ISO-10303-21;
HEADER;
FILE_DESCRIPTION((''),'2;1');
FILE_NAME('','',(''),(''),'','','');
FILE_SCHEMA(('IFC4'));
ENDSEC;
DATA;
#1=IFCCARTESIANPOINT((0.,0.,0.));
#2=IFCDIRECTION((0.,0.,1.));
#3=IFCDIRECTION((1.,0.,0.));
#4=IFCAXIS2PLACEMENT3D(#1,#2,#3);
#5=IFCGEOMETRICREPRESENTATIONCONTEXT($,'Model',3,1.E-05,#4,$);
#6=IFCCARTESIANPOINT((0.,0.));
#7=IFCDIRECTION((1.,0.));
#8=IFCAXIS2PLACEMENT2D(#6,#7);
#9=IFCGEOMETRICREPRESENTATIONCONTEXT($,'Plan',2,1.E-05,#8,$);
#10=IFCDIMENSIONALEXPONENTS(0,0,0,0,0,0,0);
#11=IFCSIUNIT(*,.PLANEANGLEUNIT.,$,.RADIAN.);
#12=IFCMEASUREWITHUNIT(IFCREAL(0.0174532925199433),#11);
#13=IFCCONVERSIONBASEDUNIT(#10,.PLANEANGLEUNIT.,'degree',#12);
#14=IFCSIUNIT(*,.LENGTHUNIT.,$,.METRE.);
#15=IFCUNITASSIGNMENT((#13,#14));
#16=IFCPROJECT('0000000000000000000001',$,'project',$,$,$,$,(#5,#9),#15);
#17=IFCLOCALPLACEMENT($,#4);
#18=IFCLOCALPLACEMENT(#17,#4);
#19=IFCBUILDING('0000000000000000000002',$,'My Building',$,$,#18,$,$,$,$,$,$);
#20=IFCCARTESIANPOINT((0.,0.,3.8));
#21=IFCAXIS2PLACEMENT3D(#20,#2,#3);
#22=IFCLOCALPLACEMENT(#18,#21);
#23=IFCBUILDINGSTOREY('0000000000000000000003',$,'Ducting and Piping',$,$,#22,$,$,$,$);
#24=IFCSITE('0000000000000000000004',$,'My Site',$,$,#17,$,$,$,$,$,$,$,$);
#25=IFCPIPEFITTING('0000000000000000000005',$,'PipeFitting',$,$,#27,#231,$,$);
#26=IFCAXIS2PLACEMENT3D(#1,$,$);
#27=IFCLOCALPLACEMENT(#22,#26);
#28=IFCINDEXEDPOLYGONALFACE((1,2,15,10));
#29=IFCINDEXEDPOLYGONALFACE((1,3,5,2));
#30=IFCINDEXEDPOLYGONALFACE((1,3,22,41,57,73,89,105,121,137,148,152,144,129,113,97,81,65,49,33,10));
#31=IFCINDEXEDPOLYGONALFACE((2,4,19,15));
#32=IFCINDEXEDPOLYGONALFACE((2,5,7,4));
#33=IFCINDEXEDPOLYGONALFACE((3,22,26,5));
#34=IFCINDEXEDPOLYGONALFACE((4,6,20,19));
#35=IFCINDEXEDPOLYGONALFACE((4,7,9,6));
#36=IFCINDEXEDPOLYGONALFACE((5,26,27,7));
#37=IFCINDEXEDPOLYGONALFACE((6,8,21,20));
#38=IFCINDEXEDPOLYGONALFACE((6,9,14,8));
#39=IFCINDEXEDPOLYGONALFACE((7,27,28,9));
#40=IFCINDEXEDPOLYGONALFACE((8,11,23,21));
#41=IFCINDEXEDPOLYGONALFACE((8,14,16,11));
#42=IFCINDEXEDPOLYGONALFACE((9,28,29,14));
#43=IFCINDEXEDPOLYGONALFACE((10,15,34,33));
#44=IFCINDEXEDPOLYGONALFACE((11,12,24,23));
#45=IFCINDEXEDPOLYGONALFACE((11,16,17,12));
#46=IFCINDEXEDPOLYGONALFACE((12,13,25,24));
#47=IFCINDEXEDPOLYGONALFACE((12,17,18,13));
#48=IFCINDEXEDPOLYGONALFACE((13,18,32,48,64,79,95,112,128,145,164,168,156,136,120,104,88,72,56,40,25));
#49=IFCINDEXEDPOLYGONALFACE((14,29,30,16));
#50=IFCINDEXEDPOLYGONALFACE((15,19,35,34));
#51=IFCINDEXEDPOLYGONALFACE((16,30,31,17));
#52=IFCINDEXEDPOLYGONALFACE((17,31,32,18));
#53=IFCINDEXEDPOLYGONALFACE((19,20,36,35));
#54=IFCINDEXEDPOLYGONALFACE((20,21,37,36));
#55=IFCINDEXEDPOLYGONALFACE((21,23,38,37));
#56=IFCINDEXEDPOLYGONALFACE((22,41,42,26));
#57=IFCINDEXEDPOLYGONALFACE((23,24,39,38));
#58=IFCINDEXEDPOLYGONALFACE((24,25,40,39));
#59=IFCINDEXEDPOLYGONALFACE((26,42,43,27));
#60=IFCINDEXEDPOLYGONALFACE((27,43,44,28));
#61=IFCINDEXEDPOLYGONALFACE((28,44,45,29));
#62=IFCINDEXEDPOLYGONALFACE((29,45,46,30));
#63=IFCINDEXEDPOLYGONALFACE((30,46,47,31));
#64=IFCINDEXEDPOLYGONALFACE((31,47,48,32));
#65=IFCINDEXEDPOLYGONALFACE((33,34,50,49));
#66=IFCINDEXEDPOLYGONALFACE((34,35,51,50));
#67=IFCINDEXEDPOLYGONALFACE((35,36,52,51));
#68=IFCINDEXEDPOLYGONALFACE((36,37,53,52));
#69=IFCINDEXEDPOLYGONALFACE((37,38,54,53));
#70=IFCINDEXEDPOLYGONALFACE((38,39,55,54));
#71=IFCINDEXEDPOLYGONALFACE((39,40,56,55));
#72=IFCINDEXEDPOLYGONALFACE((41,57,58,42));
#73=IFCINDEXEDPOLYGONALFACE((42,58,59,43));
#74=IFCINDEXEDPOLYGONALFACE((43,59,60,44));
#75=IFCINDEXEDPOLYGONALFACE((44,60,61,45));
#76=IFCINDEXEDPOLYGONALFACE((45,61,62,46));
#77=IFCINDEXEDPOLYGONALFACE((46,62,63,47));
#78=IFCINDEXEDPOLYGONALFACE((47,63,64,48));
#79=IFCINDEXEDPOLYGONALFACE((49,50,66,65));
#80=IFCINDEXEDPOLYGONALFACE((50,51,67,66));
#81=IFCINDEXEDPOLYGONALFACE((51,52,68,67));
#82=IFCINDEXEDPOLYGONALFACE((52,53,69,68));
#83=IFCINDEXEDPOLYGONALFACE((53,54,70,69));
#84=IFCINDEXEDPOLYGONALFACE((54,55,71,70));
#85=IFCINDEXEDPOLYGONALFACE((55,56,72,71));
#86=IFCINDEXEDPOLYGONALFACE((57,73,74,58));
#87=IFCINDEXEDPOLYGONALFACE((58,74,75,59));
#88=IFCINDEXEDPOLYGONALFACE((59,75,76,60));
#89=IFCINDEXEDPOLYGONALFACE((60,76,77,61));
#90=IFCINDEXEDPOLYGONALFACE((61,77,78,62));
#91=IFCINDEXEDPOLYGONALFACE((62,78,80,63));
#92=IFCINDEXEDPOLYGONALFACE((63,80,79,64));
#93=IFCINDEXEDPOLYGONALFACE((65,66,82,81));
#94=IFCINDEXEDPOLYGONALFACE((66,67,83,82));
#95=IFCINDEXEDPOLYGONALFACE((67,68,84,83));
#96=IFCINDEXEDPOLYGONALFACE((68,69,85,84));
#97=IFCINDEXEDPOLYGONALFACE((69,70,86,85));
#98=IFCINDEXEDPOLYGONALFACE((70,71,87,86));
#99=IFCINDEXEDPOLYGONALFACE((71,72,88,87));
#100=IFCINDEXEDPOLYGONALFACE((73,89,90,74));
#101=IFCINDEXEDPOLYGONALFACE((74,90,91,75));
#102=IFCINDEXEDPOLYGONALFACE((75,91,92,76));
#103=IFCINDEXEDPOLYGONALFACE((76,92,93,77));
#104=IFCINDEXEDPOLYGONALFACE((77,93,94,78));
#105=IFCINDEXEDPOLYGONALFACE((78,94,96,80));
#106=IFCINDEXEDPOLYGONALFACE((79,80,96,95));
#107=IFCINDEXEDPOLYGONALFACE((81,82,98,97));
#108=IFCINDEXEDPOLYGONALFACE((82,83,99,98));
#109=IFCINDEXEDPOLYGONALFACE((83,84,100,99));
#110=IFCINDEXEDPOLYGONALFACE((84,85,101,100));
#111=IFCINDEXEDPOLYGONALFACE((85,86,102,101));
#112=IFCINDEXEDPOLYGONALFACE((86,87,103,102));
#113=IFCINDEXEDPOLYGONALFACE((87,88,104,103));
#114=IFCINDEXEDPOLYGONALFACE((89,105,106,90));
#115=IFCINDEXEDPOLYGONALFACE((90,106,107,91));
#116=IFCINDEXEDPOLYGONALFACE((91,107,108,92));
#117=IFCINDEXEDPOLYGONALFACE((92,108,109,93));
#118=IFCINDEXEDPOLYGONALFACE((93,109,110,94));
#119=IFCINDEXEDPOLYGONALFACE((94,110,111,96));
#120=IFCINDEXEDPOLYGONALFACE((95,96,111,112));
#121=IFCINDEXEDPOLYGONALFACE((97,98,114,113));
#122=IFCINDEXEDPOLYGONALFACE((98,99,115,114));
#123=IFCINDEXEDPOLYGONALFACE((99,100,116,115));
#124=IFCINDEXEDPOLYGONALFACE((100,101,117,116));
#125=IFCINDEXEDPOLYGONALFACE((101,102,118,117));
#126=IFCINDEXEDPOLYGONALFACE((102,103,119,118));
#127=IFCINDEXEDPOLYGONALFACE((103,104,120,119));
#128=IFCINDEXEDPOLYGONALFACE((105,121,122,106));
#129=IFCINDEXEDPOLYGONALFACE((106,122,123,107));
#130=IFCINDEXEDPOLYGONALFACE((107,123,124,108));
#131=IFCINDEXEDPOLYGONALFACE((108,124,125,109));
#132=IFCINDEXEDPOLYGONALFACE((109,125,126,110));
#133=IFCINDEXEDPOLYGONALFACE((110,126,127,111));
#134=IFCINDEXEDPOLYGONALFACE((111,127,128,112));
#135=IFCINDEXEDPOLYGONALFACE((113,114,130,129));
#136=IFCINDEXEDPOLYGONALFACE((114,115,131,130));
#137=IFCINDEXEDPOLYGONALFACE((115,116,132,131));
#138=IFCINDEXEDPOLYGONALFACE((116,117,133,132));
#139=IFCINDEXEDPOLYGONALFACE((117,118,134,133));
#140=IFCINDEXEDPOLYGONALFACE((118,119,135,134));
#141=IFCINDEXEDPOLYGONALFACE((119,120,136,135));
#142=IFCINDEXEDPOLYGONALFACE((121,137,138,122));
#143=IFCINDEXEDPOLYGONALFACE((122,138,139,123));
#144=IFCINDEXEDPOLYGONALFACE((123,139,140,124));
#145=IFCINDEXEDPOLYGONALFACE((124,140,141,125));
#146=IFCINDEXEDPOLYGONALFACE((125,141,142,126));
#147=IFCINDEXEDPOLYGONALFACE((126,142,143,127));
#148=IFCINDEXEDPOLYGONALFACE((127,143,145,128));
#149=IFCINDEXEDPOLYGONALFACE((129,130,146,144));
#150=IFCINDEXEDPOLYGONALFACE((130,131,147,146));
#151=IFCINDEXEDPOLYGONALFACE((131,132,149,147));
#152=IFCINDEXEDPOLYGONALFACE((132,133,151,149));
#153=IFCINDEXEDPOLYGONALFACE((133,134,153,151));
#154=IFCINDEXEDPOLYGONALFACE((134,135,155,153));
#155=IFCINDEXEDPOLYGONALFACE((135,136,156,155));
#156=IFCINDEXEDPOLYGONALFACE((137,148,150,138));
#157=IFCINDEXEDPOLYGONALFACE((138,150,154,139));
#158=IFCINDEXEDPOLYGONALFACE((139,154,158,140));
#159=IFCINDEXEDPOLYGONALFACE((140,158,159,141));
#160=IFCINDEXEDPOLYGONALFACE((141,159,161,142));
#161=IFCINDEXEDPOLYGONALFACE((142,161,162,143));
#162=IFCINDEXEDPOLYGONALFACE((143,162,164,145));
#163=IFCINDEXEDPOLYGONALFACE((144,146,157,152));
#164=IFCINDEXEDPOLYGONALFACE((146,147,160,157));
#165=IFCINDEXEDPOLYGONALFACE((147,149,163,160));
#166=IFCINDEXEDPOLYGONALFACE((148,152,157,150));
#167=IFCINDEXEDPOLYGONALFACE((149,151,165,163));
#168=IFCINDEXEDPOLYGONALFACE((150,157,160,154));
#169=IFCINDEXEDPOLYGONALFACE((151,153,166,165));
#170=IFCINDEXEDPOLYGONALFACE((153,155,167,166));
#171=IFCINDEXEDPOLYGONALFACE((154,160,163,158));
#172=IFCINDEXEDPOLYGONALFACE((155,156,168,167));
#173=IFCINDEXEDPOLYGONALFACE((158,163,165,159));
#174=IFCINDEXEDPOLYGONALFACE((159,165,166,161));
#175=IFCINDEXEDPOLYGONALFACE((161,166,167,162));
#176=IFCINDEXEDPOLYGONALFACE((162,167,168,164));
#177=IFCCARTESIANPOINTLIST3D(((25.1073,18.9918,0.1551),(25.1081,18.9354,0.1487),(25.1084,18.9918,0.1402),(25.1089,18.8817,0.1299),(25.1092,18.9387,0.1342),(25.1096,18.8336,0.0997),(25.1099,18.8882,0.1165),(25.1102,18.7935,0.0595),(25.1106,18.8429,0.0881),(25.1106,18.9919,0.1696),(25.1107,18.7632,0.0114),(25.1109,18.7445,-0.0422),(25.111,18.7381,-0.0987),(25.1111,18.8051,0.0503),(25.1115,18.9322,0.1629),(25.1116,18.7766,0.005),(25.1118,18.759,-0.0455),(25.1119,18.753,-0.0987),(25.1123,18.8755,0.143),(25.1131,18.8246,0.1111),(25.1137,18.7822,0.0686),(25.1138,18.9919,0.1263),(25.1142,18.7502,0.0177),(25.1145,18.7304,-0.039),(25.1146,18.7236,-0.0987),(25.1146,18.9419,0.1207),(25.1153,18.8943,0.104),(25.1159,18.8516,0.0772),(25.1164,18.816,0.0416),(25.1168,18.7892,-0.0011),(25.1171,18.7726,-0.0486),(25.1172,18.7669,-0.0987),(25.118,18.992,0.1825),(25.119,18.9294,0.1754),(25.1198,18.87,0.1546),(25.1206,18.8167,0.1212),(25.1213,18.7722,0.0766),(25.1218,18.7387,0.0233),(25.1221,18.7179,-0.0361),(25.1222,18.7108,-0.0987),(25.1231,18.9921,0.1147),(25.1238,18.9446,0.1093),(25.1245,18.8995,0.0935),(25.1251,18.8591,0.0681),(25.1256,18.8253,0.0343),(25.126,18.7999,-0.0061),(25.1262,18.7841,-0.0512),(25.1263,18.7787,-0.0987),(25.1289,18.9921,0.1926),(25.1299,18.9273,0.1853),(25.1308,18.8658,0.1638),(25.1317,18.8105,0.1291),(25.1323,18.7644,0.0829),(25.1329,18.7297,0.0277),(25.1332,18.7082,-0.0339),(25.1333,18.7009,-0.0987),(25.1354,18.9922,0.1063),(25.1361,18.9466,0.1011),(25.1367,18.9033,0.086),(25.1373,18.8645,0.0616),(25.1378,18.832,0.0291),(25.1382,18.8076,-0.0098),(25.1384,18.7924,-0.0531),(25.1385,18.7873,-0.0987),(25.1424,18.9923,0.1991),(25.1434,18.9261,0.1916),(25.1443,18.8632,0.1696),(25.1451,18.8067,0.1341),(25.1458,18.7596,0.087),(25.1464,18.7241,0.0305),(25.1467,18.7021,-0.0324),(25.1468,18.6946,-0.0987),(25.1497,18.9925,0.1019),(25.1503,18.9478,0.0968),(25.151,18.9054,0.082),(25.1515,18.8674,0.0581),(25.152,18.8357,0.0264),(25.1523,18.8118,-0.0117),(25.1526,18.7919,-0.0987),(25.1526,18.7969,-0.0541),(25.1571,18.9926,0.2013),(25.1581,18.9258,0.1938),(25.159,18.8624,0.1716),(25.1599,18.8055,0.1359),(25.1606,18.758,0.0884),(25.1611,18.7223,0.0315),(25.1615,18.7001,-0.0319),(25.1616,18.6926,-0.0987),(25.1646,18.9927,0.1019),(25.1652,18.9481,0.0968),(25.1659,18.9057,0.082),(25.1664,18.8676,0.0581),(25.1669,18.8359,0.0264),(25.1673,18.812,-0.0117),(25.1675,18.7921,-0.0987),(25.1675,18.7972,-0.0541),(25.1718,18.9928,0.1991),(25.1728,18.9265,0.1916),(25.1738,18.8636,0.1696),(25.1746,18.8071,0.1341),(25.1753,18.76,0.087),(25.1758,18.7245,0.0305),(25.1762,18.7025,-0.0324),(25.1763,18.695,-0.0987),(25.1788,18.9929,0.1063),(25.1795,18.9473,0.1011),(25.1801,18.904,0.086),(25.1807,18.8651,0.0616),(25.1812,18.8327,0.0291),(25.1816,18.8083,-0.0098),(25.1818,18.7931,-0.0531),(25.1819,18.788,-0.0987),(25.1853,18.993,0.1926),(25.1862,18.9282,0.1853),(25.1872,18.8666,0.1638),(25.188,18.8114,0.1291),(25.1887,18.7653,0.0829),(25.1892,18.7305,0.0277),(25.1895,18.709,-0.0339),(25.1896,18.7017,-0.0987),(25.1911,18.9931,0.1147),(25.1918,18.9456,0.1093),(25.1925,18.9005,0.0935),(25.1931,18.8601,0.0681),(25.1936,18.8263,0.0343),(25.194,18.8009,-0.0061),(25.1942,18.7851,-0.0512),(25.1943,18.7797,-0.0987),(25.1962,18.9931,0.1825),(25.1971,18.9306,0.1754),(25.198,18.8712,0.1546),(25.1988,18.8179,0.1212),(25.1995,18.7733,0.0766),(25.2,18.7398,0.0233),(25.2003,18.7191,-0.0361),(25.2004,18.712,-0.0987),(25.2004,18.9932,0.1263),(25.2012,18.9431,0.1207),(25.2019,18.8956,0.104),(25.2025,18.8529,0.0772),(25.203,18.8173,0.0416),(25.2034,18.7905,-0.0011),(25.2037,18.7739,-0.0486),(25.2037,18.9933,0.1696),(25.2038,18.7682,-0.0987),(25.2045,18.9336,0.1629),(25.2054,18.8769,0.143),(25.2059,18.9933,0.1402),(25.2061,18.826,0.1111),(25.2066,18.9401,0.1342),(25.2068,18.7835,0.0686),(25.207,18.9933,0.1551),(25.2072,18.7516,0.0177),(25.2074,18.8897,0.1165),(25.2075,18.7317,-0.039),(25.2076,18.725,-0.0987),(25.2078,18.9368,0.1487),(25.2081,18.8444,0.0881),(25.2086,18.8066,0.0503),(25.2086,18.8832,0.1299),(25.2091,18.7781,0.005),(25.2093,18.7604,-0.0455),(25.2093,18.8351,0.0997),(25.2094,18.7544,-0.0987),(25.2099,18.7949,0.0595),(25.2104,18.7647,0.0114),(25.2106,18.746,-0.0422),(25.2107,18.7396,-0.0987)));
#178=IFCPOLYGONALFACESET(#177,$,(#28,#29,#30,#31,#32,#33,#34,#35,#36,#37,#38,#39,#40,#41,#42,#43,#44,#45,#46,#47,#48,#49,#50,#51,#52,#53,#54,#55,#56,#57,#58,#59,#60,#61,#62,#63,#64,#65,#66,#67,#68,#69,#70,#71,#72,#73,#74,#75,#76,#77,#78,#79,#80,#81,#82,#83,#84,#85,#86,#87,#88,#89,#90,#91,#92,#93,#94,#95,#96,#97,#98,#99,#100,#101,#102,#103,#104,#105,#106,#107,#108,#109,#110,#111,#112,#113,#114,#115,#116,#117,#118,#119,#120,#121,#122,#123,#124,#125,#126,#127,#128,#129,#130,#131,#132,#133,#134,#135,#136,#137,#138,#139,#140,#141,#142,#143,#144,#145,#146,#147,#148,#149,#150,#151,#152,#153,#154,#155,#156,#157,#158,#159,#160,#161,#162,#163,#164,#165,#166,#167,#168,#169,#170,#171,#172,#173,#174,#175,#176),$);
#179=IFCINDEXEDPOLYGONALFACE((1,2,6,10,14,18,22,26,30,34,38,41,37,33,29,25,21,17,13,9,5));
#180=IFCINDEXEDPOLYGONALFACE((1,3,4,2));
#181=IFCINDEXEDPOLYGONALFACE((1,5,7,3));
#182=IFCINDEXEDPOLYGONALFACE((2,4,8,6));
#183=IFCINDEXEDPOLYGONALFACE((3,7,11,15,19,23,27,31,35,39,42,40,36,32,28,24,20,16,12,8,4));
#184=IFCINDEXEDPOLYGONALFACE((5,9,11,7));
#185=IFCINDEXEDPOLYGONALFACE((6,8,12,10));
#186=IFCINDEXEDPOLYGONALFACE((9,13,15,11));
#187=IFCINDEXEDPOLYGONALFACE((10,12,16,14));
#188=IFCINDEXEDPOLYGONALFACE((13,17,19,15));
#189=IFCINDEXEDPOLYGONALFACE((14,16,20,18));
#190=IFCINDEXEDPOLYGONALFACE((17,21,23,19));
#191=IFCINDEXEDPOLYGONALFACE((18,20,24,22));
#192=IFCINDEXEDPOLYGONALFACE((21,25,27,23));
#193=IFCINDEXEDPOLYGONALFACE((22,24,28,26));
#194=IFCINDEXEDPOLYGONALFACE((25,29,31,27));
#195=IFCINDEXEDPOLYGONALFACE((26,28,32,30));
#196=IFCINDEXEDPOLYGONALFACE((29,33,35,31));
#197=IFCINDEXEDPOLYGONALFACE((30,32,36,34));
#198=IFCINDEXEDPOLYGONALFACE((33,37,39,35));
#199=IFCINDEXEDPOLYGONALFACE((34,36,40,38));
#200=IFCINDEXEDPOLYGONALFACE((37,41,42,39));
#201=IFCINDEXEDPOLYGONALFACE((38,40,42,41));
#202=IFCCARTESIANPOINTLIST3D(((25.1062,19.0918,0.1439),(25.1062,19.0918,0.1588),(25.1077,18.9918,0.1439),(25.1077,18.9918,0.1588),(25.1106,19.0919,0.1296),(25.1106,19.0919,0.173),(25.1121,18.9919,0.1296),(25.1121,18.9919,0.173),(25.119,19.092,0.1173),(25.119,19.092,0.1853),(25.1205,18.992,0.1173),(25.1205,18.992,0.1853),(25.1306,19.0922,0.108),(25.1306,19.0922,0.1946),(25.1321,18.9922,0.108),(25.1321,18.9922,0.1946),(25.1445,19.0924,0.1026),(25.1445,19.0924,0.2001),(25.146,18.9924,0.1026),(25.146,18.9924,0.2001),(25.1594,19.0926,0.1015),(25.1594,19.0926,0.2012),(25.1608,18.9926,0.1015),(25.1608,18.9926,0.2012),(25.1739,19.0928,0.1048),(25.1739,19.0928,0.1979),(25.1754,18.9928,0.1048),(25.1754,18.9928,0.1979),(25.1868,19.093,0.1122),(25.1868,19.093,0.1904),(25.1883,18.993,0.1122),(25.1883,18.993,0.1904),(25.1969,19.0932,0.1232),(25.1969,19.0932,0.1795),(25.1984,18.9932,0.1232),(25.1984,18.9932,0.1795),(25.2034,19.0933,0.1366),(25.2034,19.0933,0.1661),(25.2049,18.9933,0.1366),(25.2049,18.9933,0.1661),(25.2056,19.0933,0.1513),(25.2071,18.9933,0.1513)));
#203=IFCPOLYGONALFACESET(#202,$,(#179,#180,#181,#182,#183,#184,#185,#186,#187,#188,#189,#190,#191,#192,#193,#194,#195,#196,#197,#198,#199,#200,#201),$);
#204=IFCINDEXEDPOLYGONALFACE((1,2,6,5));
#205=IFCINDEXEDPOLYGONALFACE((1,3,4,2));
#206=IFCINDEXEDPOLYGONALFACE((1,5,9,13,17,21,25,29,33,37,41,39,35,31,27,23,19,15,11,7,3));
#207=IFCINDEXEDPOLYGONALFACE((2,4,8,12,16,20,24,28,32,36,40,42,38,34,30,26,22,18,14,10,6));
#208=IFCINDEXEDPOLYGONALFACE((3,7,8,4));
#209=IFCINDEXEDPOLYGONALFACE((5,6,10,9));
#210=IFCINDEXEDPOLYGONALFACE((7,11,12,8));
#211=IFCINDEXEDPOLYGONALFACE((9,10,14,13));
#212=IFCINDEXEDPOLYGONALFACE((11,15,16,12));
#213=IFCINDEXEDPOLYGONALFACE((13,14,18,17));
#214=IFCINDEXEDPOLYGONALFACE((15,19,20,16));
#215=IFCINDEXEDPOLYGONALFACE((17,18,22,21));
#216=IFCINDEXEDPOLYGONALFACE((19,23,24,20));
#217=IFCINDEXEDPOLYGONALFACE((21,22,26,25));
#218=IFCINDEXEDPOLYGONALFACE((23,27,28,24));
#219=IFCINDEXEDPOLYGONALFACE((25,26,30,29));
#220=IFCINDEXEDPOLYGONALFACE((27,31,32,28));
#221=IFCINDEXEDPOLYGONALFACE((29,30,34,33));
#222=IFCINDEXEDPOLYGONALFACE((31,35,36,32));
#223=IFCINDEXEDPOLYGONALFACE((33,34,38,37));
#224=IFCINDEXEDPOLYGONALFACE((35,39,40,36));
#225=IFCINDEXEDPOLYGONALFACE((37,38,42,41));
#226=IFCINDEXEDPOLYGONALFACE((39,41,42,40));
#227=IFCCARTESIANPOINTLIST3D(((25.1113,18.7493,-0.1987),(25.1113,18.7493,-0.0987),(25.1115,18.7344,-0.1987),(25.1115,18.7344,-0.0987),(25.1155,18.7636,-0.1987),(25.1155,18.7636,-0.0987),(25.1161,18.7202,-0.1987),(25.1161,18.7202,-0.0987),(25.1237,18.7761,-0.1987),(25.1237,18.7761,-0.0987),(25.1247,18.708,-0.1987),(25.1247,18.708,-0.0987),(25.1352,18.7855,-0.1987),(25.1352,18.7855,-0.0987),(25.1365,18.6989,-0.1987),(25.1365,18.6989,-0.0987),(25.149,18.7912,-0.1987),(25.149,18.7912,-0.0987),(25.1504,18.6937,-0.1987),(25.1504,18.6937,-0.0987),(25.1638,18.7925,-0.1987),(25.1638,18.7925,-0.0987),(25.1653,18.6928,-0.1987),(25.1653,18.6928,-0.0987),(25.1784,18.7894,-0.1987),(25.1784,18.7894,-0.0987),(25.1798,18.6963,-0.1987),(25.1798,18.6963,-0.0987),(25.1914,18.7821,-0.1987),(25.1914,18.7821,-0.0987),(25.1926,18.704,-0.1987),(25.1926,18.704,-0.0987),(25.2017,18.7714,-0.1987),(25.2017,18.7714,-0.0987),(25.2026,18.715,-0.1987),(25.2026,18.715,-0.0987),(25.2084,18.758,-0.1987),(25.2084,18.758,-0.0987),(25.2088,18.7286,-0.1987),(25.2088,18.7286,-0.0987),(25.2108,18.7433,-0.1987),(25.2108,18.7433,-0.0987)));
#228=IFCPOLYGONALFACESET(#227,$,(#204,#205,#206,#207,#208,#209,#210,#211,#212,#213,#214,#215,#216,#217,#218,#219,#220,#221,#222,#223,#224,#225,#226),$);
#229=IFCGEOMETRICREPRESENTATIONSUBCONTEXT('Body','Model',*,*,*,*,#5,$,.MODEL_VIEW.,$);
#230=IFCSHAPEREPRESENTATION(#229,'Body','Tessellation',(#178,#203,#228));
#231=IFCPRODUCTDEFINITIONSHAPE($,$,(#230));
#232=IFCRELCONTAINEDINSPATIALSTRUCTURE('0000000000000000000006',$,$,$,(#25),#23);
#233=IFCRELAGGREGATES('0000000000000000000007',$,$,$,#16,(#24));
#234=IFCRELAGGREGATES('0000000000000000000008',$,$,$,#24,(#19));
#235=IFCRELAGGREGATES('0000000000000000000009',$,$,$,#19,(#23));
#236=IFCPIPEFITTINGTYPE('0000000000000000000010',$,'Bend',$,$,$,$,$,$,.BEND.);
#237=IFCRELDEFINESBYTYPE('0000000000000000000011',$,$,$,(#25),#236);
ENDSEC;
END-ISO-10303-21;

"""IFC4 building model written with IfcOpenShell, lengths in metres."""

from ifc_helpers import new_model, entity, si_unit, converted_unit, frame, origin_with_axes, origin_2d_with_axis, place, context, subcontext, project, spatial, circle, extrude, source, transform, mapped, type_object, type_shapes, element, save


model = new_model("IFC4")

# Units and contexts
model_context = context("Model", 3, precision=1e-05, world=origin_with_axes())
plan_context = context("Plan", 2, precision=1e-05, world=origin_2d_with_axis())
body_context = subcontext(model_context, "Body", "Model", "MODEL_VIEW")
ifc_project = project(units=[converted_unit("PLANEANGLEUNIT", "degree", entity("IfcReal", 0.0174532925199433), si_unit("PLANEANGLEUNIT", "RADIAN"), dimensions=[0, 0, 0, 0, 0, 0, 0]), si_unit("LENGTHUNIT", "METRE")], contexts=[model_context, plan_context])

# Site, building, storey
site_placement = place(None, origin_with_axes())
site = spatial("IfcSite", under=ifc_project, at=site_placement, Name="My Site")
building_placement = place(site_placement, origin_with_axes())
building = spatial("IfcBuilding", under=site, at=building_placement, Name="My Building")
storey_placement = place(building_placement, frame((0.0, 0.0, 3.8), z_axis=(0.0, 0.0, 1.0), x_axis=(1.0, 0.0, 0.0)))
storey = spatial("IfcBuildingStorey", under=building, at=storey_placement, Name="Ducting and Piping")

# Pipe fitting
pipe_fitting_type = type_object("IfcPipeFittingType", Name="Bend", PredefinedType="BEND")
shared_shape = source(origin_with_axes(), body_context, "Body", "SolidModel", [
    entity("IfcSweptDiskSolid", entity("IfcIndexedPolyCurve", entity("IfcCartesianPointList3D", [[0.0, 0.0, 0.1], [0.0, -0.0732, 0.2768], [0.0, -0.25, 0.35]]), [entity("IfcArcIndex", [1, 2, 3])]), 0.05),
    extrude(circle(Radius=0.05), origin_with_axes(), (0.0, 0.0, 1.0), 0.1),
    extrude(circle(Radius=0.05), frame((0.0, -0.25, 0.35), z_axis=(0.0, -1.0, 0.0), x_axis=(1.0, 0.0, 0.0)), (0.0, 0.0, 1.0), 0.1),
])
type_shapes(pipe_fitting_type, [shared_shape])
for number, where, z_axis, x_axis, name in (
    (1, (25.1556, 19.0926, 0.1513), (0.014879, -0.999889, 0.0), (0.999889, 0.014879, 0.0), "PipeFitting"),
):
    element("IfcPipeFitting", number, at=place(storey_placement, frame(where, z_axis=z_axis, x_axis=x_axis)), inside=storey, type_object=pipe_fitting_type, Name=name, context=body_context, shape_type="MappedRepresentation", body=[
        mapped(shared_shape, transform((0.0, 0.0, 0.0), x_axis=(1.0, 0.0, 0.0), y_axis=(0.0, 1.0, 0.0), z_axis=(0.0, 0.0, 1.0), scale=1.0)),
    ])

save(model, "model.ifc")
